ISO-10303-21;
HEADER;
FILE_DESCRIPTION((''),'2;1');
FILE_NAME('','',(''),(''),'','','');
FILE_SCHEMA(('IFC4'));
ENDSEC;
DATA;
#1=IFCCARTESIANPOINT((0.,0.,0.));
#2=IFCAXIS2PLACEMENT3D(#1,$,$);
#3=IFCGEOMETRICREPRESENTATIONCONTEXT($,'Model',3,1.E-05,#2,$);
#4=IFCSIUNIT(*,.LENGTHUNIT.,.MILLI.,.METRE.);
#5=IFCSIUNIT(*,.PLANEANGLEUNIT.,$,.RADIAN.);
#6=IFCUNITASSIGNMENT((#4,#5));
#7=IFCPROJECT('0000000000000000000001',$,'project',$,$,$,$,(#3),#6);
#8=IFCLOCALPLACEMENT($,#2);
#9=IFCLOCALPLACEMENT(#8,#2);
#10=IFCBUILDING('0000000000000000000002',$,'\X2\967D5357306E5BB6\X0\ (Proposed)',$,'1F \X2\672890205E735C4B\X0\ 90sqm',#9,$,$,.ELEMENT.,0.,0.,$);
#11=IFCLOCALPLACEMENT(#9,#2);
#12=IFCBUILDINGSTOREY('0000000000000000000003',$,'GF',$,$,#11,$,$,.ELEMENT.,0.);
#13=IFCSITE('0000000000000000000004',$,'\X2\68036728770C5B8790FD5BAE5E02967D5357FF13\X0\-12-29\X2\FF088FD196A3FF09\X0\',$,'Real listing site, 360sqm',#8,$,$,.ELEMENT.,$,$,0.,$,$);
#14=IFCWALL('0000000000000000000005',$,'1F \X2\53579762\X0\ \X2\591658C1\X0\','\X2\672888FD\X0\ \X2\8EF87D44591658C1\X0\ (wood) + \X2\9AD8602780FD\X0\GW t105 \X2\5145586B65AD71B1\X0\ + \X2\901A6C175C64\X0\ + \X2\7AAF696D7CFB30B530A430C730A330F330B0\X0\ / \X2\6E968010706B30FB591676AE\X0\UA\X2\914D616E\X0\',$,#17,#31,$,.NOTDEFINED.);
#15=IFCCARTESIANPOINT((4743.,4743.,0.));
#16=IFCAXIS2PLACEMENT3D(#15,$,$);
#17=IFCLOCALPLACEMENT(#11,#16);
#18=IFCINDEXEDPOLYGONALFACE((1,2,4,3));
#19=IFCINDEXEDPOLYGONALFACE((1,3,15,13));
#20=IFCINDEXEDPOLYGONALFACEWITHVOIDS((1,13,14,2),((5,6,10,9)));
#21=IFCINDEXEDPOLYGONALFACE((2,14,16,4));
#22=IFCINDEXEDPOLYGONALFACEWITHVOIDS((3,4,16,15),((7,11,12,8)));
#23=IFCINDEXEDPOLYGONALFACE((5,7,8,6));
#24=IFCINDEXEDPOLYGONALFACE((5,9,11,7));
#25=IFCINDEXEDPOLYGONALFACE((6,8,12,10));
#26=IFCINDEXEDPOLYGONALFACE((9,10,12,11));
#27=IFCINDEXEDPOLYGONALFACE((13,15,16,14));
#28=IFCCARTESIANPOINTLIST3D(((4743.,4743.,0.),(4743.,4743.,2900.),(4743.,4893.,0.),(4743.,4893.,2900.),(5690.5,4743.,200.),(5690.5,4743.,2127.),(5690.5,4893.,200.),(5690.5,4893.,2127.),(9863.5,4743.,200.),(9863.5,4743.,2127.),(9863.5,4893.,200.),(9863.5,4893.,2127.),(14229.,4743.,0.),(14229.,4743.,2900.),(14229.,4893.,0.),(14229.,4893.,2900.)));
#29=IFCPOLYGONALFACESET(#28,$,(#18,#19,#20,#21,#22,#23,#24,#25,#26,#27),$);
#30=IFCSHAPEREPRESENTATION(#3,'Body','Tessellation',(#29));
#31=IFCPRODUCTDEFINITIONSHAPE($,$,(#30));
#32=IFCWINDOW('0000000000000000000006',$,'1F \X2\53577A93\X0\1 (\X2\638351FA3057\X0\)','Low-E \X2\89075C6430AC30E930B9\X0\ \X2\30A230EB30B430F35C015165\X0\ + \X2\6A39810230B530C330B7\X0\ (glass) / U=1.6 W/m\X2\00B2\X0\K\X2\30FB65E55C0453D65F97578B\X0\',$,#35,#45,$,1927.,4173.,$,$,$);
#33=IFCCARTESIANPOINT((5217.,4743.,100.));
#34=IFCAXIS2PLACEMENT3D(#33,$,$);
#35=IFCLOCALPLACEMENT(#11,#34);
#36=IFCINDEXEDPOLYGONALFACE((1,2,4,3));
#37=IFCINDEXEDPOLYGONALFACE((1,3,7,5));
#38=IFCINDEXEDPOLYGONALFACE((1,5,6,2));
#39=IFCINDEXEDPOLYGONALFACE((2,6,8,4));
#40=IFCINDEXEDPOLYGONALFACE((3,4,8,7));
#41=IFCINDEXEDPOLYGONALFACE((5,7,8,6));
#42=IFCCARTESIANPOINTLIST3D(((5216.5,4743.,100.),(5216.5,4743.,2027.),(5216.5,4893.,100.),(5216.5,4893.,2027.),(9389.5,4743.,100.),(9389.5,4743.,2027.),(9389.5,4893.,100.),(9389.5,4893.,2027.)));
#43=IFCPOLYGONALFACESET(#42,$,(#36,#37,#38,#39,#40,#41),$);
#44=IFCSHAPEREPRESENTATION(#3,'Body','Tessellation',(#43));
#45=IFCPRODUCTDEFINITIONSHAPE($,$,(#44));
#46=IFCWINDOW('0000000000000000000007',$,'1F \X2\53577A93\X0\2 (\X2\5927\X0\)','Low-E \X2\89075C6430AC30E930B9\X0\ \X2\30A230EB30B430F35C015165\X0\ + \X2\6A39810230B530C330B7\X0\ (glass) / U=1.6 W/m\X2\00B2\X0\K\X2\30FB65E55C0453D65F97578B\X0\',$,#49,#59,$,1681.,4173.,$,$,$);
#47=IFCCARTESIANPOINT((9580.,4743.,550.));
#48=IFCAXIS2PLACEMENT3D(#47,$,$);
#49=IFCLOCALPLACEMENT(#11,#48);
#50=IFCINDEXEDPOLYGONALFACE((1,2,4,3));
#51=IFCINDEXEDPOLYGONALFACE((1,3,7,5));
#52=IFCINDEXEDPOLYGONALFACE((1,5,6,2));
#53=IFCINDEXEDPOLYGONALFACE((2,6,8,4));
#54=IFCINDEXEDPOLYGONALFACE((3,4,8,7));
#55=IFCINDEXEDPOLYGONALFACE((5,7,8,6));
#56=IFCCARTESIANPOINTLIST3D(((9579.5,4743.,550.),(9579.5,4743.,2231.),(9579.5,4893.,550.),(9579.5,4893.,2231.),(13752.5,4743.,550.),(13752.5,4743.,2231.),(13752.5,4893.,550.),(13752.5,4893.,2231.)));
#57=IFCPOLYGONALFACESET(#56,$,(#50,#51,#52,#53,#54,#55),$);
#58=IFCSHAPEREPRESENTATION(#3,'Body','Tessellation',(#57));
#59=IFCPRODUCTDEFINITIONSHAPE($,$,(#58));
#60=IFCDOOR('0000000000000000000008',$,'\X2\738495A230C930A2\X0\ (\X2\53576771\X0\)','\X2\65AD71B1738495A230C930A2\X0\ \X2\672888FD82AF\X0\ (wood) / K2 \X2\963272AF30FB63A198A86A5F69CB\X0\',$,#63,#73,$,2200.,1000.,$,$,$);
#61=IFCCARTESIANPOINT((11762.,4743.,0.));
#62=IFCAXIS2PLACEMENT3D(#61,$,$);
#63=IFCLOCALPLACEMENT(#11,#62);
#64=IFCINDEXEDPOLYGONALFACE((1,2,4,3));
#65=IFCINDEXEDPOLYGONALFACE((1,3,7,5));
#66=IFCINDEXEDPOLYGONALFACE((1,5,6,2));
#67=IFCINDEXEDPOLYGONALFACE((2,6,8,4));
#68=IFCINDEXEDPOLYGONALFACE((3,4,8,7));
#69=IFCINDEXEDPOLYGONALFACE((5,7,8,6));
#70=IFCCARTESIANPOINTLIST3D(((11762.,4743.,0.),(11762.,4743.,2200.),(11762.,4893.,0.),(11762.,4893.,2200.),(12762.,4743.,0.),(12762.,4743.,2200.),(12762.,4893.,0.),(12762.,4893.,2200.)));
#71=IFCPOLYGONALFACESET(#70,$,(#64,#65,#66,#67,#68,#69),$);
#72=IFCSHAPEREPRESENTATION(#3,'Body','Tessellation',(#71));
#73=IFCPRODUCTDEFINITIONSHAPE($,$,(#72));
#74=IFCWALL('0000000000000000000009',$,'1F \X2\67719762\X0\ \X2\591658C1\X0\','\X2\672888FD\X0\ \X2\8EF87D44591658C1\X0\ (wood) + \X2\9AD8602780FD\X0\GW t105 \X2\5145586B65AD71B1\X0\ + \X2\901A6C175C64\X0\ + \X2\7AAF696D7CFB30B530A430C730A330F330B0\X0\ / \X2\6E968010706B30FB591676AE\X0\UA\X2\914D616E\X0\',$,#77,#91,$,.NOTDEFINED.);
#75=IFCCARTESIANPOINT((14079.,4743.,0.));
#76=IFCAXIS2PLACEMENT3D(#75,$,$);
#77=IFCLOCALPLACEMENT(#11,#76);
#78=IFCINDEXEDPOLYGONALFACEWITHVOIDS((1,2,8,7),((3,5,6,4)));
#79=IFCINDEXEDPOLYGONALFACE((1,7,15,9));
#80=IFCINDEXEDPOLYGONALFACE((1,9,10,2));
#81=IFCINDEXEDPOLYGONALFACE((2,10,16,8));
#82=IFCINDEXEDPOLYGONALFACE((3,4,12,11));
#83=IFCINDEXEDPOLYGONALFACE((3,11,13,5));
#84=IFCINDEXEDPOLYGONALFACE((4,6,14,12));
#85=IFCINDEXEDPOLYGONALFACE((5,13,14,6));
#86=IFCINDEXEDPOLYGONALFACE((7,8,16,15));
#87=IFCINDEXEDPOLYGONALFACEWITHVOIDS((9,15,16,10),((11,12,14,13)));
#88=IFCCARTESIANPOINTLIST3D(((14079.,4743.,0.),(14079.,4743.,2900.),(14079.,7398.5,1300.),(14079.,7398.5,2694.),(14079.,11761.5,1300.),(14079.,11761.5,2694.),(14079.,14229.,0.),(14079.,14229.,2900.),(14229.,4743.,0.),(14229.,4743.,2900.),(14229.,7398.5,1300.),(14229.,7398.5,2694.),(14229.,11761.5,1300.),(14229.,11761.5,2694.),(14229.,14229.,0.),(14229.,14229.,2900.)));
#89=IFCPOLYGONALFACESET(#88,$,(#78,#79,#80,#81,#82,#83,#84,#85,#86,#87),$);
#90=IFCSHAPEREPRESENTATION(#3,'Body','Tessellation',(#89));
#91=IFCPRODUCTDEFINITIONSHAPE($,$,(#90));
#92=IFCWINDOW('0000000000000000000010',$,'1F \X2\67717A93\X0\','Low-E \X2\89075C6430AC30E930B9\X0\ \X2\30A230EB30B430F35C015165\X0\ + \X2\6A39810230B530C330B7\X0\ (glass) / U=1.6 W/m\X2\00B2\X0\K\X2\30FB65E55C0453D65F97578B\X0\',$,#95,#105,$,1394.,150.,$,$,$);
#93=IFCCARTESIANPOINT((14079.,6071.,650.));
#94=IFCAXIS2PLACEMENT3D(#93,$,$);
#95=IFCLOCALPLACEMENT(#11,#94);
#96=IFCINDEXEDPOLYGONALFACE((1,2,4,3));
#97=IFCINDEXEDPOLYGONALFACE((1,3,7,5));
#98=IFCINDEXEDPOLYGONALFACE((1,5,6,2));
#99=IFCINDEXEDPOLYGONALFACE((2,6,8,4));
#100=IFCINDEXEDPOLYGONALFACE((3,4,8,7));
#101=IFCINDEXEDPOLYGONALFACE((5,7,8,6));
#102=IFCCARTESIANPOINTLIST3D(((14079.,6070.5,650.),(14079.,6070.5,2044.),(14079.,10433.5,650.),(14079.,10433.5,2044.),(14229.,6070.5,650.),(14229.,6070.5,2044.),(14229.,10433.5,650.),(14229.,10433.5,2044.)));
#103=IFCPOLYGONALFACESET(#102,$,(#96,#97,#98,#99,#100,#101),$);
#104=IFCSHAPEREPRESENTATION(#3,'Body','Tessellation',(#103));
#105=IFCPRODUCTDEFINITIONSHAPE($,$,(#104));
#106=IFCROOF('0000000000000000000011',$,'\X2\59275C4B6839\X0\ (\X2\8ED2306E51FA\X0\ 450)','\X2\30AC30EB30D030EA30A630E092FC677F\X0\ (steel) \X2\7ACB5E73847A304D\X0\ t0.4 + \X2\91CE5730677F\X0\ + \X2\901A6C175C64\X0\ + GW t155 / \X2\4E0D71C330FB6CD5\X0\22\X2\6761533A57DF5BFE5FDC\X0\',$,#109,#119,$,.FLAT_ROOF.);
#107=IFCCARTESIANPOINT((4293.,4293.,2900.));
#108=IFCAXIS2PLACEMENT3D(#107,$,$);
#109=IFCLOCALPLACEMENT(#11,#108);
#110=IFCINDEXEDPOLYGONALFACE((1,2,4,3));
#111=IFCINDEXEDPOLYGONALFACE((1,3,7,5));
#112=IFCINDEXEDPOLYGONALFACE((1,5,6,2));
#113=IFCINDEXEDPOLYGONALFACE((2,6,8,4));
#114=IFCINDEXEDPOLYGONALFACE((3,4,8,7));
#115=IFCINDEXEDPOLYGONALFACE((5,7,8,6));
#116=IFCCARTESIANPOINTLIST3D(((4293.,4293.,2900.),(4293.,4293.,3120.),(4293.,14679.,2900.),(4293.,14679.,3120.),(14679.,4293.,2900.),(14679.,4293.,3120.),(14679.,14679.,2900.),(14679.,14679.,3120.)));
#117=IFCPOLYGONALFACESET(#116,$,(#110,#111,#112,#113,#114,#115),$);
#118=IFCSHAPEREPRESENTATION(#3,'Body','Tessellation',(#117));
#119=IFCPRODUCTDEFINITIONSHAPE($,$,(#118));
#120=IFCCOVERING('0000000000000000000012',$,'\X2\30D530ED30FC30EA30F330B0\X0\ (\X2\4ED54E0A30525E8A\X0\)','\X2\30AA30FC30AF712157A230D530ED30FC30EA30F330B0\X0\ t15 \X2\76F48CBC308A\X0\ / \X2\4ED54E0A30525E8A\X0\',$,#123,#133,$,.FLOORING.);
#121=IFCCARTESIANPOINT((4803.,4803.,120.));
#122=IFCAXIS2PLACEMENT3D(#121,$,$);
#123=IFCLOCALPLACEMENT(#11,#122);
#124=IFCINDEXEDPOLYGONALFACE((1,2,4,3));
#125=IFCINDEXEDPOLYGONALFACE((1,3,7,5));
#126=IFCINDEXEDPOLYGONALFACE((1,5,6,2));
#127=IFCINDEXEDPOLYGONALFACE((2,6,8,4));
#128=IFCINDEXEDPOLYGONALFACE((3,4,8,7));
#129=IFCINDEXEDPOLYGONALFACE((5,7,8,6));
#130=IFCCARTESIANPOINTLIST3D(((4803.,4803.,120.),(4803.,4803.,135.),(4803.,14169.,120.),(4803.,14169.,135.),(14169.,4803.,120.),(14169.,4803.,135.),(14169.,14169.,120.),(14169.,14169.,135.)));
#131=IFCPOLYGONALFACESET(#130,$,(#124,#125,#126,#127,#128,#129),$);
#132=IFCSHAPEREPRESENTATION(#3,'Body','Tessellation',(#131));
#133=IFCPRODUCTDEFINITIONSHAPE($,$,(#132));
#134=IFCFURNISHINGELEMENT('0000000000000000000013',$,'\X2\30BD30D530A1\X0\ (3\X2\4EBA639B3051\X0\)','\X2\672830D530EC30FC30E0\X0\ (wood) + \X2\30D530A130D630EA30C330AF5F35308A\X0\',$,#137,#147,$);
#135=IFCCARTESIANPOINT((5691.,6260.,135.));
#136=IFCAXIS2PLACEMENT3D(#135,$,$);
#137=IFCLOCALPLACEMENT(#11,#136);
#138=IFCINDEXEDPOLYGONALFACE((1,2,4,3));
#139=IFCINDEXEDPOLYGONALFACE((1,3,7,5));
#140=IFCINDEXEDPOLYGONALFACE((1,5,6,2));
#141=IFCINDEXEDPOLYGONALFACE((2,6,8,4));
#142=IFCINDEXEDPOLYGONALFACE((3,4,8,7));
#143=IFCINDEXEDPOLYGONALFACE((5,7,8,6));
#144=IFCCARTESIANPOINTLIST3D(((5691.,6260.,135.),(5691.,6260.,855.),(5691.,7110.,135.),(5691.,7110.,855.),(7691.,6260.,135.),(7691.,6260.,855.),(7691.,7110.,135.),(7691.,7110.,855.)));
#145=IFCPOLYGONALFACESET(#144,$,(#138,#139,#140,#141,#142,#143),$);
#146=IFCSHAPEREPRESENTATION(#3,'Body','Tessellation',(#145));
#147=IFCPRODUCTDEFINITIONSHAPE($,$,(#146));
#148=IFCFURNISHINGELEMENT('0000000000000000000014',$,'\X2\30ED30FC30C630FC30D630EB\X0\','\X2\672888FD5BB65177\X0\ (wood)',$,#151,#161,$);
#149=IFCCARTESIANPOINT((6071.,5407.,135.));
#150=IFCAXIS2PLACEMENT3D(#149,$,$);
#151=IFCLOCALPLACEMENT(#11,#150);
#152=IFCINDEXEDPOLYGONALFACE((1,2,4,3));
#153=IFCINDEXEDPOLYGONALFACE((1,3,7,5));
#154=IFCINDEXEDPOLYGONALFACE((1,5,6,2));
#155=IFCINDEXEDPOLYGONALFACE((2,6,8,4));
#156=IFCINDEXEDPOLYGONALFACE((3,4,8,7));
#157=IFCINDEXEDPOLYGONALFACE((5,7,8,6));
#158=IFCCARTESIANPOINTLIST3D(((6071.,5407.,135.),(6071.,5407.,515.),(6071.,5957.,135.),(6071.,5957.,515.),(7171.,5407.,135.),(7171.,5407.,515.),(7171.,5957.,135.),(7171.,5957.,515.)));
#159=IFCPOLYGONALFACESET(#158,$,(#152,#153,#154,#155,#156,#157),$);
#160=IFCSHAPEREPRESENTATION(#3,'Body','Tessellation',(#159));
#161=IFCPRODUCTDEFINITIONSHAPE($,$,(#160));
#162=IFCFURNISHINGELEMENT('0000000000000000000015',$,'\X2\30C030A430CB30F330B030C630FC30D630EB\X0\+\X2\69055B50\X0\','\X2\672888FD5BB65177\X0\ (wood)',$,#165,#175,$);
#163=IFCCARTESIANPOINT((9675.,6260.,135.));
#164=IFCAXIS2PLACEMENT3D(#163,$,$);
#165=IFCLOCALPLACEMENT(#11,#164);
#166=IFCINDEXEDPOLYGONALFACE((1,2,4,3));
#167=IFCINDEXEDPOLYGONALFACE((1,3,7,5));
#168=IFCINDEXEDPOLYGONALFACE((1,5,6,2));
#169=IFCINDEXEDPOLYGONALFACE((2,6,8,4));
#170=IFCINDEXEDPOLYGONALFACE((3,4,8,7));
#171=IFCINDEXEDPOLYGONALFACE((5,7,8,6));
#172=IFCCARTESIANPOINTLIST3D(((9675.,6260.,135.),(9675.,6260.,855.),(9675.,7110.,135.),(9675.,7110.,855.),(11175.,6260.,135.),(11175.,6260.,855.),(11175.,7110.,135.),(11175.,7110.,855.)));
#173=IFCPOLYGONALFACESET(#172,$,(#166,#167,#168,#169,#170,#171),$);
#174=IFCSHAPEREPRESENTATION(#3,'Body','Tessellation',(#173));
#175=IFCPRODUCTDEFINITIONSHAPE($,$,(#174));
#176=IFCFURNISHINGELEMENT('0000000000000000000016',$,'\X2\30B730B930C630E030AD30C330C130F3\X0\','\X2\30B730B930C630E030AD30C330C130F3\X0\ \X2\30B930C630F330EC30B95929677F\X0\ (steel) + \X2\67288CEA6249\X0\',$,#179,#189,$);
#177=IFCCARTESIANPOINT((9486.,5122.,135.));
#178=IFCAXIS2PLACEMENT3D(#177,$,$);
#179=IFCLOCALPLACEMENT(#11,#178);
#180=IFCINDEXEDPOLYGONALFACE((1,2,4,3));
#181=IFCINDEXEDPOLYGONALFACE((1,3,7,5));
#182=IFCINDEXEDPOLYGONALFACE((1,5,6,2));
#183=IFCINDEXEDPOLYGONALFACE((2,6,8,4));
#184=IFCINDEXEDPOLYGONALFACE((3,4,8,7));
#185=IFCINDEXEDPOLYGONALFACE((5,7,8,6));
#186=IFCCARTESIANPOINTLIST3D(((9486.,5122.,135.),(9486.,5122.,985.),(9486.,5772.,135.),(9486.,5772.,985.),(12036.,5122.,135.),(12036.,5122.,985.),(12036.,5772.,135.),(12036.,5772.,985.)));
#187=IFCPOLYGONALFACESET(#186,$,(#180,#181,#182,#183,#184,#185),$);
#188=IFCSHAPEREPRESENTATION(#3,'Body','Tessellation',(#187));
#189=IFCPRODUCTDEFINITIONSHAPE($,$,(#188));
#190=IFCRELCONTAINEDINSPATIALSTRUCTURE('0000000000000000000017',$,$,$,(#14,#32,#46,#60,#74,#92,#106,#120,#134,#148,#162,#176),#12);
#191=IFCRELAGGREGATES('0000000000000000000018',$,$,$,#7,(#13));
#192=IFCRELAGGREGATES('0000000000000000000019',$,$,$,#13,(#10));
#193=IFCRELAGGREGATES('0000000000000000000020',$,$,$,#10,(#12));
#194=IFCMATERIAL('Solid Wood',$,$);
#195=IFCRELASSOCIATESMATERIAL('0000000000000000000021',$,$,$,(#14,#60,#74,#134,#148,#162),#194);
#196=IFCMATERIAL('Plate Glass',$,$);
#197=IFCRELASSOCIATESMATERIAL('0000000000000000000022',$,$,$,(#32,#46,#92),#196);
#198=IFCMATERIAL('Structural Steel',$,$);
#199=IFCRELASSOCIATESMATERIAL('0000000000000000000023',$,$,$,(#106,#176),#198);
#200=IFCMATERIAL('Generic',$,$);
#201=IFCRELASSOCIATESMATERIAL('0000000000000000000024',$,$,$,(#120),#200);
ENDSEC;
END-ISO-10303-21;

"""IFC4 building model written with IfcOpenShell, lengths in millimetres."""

from ifc_helpers import new_model, si_unit, frame, frame_2d, origin, place, context, project, spatial, rectangle, extrude, material, element, fill, save


model = new_model("IFC4")

# Units and contexts
model_context = context("Model", 3, precision=1e-05, world=origin())
ifc_project = project(units=[si_unit("LENGTHUNIT", "METRE", prefix="MILLI"), si_unit("PLANEANGLEUNIT", "RADIAN")], contexts=[model_context])

# Site, building, storey
site_placement = place(None, origin())
site = spatial("IfcSite", under=ifc_project, at=site_placement, Name="栃木県宇都宮市陽南３-12-29（近隣）", ObjectType="Real listing site, 360sqm", CompositionType="ELEMENT", RefElevation=0.0)
building_placement = place(site_placement, origin())
building = spatial("IfcBuilding", under=site, at=building_placement, Name="陽南の家 (Proposed)", ObjectType="1F 木造平屋 90sqm", CompositionType="ELEMENT", ElevationOfRefHeight=0.0, ElevationOfTerrain=0.0)
storey_placement = place(building_placement, origin())
storey = spatial("IfcBuildingStorey", under=building, at=storey_placement, Name="GF", CompositionType="ELEMENT", Elevation=0.0)

# Shared definitions
ifc_material_1 = material(Name="Solid Wood")

# Wall, openings, windows, door
wall_1_placement = place(storey_placement, frame((4743.0, 4743.0, 0.0)))
wall_1 = element("IfcWall", 1, at=wall_1_placement, inside=storey, material=ifc_material_1, Name="1F 南面 外壁", Description="木製 軸組外壁 (wood) + 高性能GW t105 充填断熱 + 通気層 + 窯業系サイディング / 準耐火・外皮UA配慮", PredefinedType="NOTDEFINED", context=model_context, shape_type="SweptSolid", body=[
    extrude(rectangle(XDim=9486.0, YDim=150.0, at=frame_2d((4743.0, 75.0))), frame((4743.0, 4743.0, 0.0)), (0.0, 0.0, 1.0), 2900.0),
])
opening_1_placement = place(storey_placement, frame((5217.0, 4743.0, 100.0)))
opening_1 = element("IfcOpeningElement", 2, at=opening_1_placement, cuts=wall_1, PredefinedType="NOTDEFINED", context=model_context, shape_type="SweptSolid", body=[
    extrude(rectangle(XDim=4173.0, YDim=150.0, at=frame_2d((2086.0, 75.0))), frame((5217.0, 4743.0, 100.0)), (0.0, 0.0, 1.0), 1927.0),
])
opening_2_placement = place(storey_placement, frame((9580.0, 4743.0, 550.0)))
opening_2 = element("IfcOpeningElement", 3, at=opening_2_placement, cuts=wall_1, PredefinedType="NOTDEFINED", context=model_context, shape_type="SweptSolid", body=[
    extrude(rectangle(XDim=4173.0, YDim=150.0, at=frame_2d((2086.0, 75.0))), frame((9580.0, 4743.0, 550.0)), (0.0, 0.0, 1.0), 1681.0),
])
opening_3_placement = place(storey_placement, frame((11762.0, 4743.0, 0.0)))
opening_3 = element("IfcOpeningElement", 4, at=opening_3_placement, cuts=wall_1, PredefinedType="NOTDEFINED", context=model_context, shape_type="SweptSolid", body=[
    extrude(rectangle(XDim=1000.0, YDim=150.0, at=frame_2d((500.0, 75.0))), frame((11762.0, 4743.0, 0.0)), (0.0, 0.0, 1.0), 2200.0),
])
ifc_material_2 = material(Name="Plate Glass")
window_1_placement = place(storey_placement, frame((5217.0, 4743.0, 100.0)))
window_1 = element("IfcWindow", 5, at=window_1_placement, inside=storey, material=ifc_material_2, Name="1F 南窓1 (掃出し)", Description="Low-E 複層ガラス アルゴン封入 + 樹脂サッシ (glass) / U=1.6 W/m²K・日射取得型", OverallHeight=1927.0, OverallWidth=4173.0, context=model_context, shape_type="SweptSolid", body=[
    extrude(rectangle(XDim=4173.0, YDim=150.0, at=frame_2d((2086.0, 75.0))), frame((5217.0, 4743.0, 100.0)), (0.0, 0.0, 1.0), 1927.0),
])
fill(opening_1, window_1)
window_2_placement = place(storey_placement, frame((9580.0, 4743.0, 550.0)))
window_2 = element("IfcWindow", 6, at=window_2_placement, inside=storey, material=ifc_material_2, Name="1F 南窓2 (大)", Description="Low-E 複層ガラス アルゴン封入 + 樹脂サッシ (glass) / U=1.6 W/m²K・日射取得型", OverallHeight=1681.0, OverallWidth=4173.0, context=model_context, shape_type="SweptSolid", body=[
    extrude(rectangle(XDim=4173.0, YDim=150.0, at=frame_2d((2086.0, 75.0))), frame((9580.0, 4743.0, 550.0)), (0.0, 0.0, 1.0), 1681.0),
])
fill(opening_2, window_2)
door_placement = place(storey_placement, frame((11762.0, 4743.0, 0.0)))
door = element("IfcDoor", 7, at=door_placement, inside=storey, material=ifc_material_1, Name="玄関ドア (南東)", Description="断熱玄関ドア 木製芯 (wood) / K2 防犯・採風機構", OverallHeight=2200.0, OverallWidth=1000.0, context=model_context, shape_type="SweptSolid", body=[
    extrude(rectangle(XDim=1000.0, YDim=150.0, at=frame_2d((500.0, 75.0))), frame((11762.0, 4743.0, 0.0)), (0.0, 0.0, 1.0), 2200.0),
])
fill(opening_3, door)

# Wall, opening, window
wall_2_placement = place(storey_placement, frame((14079.0, 4743.0, 0.0)))
wall_2 = element("IfcWall", 8, at=wall_2_placement, inside=storey, material=ifc_material_1, Name="1F 東面 外壁", Description="木製 軸組外壁 (wood) + 高性能GW t105 充填断熱 + 通気層 + 窯業系サイディング / 準耐火・外皮UA配慮", PredefinedType="NOTDEFINED", context=model_context, shape_type="SweptSolid", body=[
    extrude(rectangle(XDim=150.0, YDim=9486.0, at=frame_2d((75.0, 4743.0))), frame((14079.0, 4743.0, 0.0)), (0.0, 0.0, 1.0), 2900.0),
])
opening_4_placement = place(storey_placement, frame((14079.0, 6071.0, 650.0)))
opening_4 = element("IfcOpeningElement", 9, at=opening_4_placement, cuts=wall_2, PredefinedType="NOTDEFINED", context=model_context, shape_type="SweptSolid", body=[
    extrude(rectangle(XDim=150.0, YDim=4363.0, at=frame_2d((75.0, 2181.0))), frame((14079.0, 6071.0, 650.0)), (0.0, 0.0, 1.0), 1394.0),
])
window_3_placement = place(storey_placement, frame((14079.0, 6071.0, 650.0)))
window_3 = element("IfcWindow", 10, at=window_3_placement, inside=storey, material=ifc_material_2, Name="1F 東窓", Description="Low-E 複層ガラス アルゴン封入 + 樹脂サッシ (glass) / U=1.6 W/m²K・日射取得型", OverallHeight=1394.0, OverallWidth=150.0, context=model_context, shape_type="SweptSolid", body=[
    extrude(rectangle(XDim=150.0, YDim=4363.0, at=frame_2d((75.0, 2181.0))), frame((14079.0, 6071.0, 650.0)), (0.0, 0.0, 1.0), 1394.0),
])
fill(opening_4, window_3)

# Roof
ifc_material_3 = material(Name="Structural Steel")
roof_placement = place(storey_placement, frame((4293.0, 4293.0, 2900.0)))
element("IfcRoof", 11, at=roof_placement, inside=storey, material=ifc_material_3, Name="大屋根 (軒の出 450)", Description="ガルバリウム鋼板 (steel) 立平葺き t0.4 + 野地板 + 通気層 + GW t155 / 不燃・法22条区域対応", PredefinedType="FLAT_ROOF", context=model_context, shape_type="SweptSolid", body=[
    extrude(rectangle(XDim=10386.0, YDim=10386.0, at=frame_2d((5193.0, 5193.0))), frame((4293.0, 4293.0, 2900.0)), (0.0, 0.0, 1.0), 220.0),
])

# Covering
ifc_material_4 = material(Name="Generic")
covering_placement = place(storey_placement, frame((4803.0, 4803.0, 120.0)))
element("IfcCovering", 12, at=covering_placement, inside=storey, material=ifc_material_4, Name="フローリング (仕上げ床)", Description="オーク無垢フローリング t15 直貼り / 仕上げ床", PredefinedType="FLOORING", context=model_context, shape_type="SweptSolid", body=[
    extrude(rectangle(XDim=9366.0, YDim=9366.0, at=frame_2d((4683.0, 4683.0))), frame((4803.0, 4803.0, 120.0)), (0.0, 0.0, 1.0), 15.0),
])

# Furnishing elements
furnishing_1_placement = place(storey_placement, frame((5691.0, 6260.0, 135.0)))
element("IfcFurnishingElement", 13, at=furnishing_1_placement, inside=storey, material=ifc_material_1, Name="ソファ (3人掛け)", Description="木フレーム (wood) + ファブリック張り", context=model_context, shape_type="SweptSolid", body=[
    extrude(rectangle(XDim=2000.0, YDim=850.0, at=frame_2d((1000.0, 425.0))), frame((5691.0, 6260.0, 135.0)), (0.0, 0.0, 1.0), 720.0),
])
furnishing_2_placement = place(storey_placement, frame((6071.0, 5407.0, 135.0)))
element("IfcFurnishingElement", 14, at=furnishing_2_placement, inside=storey, material=ifc_material_1, Name="ローテーブル", Description="木製家具 (wood)", context=model_context, shape_type="SweptSolid", body=[
    extrude(rectangle(XDim=1100.0, YDim=550.0, at=frame_2d((550.0, 275.0))), frame((6071.0, 5407.0, 135.0)), (0.0, 0.0, 1.0), 380.0),
])
furnishing_3_placement = place(storey_placement, frame((9675.0, 6260.0, 135.0)))
element("IfcFurnishingElement", 15, at=furnishing_3_placement, inside=storey, material=ifc_material_1, Name="ダイニングテーブル+椅子", Description="木製家具 (wood)", context=model_context, shape_type="SweptSolid", body=[
    extrude(rectangle(XDim=1500.0, YDim=850.0, at=frame_2d((750.0, 425.0))), frame((9675.0, 6260.0, 135.0)), (0.0, 0.0, 1.0), 720.0),
])
furnishing_4_placement = place(storey_placement, frame((9486.0, 5122.0, 135.0)))
element("IfcFurnishingElement", 16, at=furnishing_4_placement, inside=storey, material=ifc_material_3, Name="システムキッチン", Description="システムキッチン ステンレス天板 (steel) + 木質扉", context=model_context, shape_type="SweptSolid", body=[
    extrude(rectangle(XDim=2550.0, YDim=650.0, at=frame_2d((1275.0, 325.0))), frame((9486.0, 5122.0, 135.0)), (0.0, 0.0, 1.0), 850.0),
])

save(model, "model.ifc")
